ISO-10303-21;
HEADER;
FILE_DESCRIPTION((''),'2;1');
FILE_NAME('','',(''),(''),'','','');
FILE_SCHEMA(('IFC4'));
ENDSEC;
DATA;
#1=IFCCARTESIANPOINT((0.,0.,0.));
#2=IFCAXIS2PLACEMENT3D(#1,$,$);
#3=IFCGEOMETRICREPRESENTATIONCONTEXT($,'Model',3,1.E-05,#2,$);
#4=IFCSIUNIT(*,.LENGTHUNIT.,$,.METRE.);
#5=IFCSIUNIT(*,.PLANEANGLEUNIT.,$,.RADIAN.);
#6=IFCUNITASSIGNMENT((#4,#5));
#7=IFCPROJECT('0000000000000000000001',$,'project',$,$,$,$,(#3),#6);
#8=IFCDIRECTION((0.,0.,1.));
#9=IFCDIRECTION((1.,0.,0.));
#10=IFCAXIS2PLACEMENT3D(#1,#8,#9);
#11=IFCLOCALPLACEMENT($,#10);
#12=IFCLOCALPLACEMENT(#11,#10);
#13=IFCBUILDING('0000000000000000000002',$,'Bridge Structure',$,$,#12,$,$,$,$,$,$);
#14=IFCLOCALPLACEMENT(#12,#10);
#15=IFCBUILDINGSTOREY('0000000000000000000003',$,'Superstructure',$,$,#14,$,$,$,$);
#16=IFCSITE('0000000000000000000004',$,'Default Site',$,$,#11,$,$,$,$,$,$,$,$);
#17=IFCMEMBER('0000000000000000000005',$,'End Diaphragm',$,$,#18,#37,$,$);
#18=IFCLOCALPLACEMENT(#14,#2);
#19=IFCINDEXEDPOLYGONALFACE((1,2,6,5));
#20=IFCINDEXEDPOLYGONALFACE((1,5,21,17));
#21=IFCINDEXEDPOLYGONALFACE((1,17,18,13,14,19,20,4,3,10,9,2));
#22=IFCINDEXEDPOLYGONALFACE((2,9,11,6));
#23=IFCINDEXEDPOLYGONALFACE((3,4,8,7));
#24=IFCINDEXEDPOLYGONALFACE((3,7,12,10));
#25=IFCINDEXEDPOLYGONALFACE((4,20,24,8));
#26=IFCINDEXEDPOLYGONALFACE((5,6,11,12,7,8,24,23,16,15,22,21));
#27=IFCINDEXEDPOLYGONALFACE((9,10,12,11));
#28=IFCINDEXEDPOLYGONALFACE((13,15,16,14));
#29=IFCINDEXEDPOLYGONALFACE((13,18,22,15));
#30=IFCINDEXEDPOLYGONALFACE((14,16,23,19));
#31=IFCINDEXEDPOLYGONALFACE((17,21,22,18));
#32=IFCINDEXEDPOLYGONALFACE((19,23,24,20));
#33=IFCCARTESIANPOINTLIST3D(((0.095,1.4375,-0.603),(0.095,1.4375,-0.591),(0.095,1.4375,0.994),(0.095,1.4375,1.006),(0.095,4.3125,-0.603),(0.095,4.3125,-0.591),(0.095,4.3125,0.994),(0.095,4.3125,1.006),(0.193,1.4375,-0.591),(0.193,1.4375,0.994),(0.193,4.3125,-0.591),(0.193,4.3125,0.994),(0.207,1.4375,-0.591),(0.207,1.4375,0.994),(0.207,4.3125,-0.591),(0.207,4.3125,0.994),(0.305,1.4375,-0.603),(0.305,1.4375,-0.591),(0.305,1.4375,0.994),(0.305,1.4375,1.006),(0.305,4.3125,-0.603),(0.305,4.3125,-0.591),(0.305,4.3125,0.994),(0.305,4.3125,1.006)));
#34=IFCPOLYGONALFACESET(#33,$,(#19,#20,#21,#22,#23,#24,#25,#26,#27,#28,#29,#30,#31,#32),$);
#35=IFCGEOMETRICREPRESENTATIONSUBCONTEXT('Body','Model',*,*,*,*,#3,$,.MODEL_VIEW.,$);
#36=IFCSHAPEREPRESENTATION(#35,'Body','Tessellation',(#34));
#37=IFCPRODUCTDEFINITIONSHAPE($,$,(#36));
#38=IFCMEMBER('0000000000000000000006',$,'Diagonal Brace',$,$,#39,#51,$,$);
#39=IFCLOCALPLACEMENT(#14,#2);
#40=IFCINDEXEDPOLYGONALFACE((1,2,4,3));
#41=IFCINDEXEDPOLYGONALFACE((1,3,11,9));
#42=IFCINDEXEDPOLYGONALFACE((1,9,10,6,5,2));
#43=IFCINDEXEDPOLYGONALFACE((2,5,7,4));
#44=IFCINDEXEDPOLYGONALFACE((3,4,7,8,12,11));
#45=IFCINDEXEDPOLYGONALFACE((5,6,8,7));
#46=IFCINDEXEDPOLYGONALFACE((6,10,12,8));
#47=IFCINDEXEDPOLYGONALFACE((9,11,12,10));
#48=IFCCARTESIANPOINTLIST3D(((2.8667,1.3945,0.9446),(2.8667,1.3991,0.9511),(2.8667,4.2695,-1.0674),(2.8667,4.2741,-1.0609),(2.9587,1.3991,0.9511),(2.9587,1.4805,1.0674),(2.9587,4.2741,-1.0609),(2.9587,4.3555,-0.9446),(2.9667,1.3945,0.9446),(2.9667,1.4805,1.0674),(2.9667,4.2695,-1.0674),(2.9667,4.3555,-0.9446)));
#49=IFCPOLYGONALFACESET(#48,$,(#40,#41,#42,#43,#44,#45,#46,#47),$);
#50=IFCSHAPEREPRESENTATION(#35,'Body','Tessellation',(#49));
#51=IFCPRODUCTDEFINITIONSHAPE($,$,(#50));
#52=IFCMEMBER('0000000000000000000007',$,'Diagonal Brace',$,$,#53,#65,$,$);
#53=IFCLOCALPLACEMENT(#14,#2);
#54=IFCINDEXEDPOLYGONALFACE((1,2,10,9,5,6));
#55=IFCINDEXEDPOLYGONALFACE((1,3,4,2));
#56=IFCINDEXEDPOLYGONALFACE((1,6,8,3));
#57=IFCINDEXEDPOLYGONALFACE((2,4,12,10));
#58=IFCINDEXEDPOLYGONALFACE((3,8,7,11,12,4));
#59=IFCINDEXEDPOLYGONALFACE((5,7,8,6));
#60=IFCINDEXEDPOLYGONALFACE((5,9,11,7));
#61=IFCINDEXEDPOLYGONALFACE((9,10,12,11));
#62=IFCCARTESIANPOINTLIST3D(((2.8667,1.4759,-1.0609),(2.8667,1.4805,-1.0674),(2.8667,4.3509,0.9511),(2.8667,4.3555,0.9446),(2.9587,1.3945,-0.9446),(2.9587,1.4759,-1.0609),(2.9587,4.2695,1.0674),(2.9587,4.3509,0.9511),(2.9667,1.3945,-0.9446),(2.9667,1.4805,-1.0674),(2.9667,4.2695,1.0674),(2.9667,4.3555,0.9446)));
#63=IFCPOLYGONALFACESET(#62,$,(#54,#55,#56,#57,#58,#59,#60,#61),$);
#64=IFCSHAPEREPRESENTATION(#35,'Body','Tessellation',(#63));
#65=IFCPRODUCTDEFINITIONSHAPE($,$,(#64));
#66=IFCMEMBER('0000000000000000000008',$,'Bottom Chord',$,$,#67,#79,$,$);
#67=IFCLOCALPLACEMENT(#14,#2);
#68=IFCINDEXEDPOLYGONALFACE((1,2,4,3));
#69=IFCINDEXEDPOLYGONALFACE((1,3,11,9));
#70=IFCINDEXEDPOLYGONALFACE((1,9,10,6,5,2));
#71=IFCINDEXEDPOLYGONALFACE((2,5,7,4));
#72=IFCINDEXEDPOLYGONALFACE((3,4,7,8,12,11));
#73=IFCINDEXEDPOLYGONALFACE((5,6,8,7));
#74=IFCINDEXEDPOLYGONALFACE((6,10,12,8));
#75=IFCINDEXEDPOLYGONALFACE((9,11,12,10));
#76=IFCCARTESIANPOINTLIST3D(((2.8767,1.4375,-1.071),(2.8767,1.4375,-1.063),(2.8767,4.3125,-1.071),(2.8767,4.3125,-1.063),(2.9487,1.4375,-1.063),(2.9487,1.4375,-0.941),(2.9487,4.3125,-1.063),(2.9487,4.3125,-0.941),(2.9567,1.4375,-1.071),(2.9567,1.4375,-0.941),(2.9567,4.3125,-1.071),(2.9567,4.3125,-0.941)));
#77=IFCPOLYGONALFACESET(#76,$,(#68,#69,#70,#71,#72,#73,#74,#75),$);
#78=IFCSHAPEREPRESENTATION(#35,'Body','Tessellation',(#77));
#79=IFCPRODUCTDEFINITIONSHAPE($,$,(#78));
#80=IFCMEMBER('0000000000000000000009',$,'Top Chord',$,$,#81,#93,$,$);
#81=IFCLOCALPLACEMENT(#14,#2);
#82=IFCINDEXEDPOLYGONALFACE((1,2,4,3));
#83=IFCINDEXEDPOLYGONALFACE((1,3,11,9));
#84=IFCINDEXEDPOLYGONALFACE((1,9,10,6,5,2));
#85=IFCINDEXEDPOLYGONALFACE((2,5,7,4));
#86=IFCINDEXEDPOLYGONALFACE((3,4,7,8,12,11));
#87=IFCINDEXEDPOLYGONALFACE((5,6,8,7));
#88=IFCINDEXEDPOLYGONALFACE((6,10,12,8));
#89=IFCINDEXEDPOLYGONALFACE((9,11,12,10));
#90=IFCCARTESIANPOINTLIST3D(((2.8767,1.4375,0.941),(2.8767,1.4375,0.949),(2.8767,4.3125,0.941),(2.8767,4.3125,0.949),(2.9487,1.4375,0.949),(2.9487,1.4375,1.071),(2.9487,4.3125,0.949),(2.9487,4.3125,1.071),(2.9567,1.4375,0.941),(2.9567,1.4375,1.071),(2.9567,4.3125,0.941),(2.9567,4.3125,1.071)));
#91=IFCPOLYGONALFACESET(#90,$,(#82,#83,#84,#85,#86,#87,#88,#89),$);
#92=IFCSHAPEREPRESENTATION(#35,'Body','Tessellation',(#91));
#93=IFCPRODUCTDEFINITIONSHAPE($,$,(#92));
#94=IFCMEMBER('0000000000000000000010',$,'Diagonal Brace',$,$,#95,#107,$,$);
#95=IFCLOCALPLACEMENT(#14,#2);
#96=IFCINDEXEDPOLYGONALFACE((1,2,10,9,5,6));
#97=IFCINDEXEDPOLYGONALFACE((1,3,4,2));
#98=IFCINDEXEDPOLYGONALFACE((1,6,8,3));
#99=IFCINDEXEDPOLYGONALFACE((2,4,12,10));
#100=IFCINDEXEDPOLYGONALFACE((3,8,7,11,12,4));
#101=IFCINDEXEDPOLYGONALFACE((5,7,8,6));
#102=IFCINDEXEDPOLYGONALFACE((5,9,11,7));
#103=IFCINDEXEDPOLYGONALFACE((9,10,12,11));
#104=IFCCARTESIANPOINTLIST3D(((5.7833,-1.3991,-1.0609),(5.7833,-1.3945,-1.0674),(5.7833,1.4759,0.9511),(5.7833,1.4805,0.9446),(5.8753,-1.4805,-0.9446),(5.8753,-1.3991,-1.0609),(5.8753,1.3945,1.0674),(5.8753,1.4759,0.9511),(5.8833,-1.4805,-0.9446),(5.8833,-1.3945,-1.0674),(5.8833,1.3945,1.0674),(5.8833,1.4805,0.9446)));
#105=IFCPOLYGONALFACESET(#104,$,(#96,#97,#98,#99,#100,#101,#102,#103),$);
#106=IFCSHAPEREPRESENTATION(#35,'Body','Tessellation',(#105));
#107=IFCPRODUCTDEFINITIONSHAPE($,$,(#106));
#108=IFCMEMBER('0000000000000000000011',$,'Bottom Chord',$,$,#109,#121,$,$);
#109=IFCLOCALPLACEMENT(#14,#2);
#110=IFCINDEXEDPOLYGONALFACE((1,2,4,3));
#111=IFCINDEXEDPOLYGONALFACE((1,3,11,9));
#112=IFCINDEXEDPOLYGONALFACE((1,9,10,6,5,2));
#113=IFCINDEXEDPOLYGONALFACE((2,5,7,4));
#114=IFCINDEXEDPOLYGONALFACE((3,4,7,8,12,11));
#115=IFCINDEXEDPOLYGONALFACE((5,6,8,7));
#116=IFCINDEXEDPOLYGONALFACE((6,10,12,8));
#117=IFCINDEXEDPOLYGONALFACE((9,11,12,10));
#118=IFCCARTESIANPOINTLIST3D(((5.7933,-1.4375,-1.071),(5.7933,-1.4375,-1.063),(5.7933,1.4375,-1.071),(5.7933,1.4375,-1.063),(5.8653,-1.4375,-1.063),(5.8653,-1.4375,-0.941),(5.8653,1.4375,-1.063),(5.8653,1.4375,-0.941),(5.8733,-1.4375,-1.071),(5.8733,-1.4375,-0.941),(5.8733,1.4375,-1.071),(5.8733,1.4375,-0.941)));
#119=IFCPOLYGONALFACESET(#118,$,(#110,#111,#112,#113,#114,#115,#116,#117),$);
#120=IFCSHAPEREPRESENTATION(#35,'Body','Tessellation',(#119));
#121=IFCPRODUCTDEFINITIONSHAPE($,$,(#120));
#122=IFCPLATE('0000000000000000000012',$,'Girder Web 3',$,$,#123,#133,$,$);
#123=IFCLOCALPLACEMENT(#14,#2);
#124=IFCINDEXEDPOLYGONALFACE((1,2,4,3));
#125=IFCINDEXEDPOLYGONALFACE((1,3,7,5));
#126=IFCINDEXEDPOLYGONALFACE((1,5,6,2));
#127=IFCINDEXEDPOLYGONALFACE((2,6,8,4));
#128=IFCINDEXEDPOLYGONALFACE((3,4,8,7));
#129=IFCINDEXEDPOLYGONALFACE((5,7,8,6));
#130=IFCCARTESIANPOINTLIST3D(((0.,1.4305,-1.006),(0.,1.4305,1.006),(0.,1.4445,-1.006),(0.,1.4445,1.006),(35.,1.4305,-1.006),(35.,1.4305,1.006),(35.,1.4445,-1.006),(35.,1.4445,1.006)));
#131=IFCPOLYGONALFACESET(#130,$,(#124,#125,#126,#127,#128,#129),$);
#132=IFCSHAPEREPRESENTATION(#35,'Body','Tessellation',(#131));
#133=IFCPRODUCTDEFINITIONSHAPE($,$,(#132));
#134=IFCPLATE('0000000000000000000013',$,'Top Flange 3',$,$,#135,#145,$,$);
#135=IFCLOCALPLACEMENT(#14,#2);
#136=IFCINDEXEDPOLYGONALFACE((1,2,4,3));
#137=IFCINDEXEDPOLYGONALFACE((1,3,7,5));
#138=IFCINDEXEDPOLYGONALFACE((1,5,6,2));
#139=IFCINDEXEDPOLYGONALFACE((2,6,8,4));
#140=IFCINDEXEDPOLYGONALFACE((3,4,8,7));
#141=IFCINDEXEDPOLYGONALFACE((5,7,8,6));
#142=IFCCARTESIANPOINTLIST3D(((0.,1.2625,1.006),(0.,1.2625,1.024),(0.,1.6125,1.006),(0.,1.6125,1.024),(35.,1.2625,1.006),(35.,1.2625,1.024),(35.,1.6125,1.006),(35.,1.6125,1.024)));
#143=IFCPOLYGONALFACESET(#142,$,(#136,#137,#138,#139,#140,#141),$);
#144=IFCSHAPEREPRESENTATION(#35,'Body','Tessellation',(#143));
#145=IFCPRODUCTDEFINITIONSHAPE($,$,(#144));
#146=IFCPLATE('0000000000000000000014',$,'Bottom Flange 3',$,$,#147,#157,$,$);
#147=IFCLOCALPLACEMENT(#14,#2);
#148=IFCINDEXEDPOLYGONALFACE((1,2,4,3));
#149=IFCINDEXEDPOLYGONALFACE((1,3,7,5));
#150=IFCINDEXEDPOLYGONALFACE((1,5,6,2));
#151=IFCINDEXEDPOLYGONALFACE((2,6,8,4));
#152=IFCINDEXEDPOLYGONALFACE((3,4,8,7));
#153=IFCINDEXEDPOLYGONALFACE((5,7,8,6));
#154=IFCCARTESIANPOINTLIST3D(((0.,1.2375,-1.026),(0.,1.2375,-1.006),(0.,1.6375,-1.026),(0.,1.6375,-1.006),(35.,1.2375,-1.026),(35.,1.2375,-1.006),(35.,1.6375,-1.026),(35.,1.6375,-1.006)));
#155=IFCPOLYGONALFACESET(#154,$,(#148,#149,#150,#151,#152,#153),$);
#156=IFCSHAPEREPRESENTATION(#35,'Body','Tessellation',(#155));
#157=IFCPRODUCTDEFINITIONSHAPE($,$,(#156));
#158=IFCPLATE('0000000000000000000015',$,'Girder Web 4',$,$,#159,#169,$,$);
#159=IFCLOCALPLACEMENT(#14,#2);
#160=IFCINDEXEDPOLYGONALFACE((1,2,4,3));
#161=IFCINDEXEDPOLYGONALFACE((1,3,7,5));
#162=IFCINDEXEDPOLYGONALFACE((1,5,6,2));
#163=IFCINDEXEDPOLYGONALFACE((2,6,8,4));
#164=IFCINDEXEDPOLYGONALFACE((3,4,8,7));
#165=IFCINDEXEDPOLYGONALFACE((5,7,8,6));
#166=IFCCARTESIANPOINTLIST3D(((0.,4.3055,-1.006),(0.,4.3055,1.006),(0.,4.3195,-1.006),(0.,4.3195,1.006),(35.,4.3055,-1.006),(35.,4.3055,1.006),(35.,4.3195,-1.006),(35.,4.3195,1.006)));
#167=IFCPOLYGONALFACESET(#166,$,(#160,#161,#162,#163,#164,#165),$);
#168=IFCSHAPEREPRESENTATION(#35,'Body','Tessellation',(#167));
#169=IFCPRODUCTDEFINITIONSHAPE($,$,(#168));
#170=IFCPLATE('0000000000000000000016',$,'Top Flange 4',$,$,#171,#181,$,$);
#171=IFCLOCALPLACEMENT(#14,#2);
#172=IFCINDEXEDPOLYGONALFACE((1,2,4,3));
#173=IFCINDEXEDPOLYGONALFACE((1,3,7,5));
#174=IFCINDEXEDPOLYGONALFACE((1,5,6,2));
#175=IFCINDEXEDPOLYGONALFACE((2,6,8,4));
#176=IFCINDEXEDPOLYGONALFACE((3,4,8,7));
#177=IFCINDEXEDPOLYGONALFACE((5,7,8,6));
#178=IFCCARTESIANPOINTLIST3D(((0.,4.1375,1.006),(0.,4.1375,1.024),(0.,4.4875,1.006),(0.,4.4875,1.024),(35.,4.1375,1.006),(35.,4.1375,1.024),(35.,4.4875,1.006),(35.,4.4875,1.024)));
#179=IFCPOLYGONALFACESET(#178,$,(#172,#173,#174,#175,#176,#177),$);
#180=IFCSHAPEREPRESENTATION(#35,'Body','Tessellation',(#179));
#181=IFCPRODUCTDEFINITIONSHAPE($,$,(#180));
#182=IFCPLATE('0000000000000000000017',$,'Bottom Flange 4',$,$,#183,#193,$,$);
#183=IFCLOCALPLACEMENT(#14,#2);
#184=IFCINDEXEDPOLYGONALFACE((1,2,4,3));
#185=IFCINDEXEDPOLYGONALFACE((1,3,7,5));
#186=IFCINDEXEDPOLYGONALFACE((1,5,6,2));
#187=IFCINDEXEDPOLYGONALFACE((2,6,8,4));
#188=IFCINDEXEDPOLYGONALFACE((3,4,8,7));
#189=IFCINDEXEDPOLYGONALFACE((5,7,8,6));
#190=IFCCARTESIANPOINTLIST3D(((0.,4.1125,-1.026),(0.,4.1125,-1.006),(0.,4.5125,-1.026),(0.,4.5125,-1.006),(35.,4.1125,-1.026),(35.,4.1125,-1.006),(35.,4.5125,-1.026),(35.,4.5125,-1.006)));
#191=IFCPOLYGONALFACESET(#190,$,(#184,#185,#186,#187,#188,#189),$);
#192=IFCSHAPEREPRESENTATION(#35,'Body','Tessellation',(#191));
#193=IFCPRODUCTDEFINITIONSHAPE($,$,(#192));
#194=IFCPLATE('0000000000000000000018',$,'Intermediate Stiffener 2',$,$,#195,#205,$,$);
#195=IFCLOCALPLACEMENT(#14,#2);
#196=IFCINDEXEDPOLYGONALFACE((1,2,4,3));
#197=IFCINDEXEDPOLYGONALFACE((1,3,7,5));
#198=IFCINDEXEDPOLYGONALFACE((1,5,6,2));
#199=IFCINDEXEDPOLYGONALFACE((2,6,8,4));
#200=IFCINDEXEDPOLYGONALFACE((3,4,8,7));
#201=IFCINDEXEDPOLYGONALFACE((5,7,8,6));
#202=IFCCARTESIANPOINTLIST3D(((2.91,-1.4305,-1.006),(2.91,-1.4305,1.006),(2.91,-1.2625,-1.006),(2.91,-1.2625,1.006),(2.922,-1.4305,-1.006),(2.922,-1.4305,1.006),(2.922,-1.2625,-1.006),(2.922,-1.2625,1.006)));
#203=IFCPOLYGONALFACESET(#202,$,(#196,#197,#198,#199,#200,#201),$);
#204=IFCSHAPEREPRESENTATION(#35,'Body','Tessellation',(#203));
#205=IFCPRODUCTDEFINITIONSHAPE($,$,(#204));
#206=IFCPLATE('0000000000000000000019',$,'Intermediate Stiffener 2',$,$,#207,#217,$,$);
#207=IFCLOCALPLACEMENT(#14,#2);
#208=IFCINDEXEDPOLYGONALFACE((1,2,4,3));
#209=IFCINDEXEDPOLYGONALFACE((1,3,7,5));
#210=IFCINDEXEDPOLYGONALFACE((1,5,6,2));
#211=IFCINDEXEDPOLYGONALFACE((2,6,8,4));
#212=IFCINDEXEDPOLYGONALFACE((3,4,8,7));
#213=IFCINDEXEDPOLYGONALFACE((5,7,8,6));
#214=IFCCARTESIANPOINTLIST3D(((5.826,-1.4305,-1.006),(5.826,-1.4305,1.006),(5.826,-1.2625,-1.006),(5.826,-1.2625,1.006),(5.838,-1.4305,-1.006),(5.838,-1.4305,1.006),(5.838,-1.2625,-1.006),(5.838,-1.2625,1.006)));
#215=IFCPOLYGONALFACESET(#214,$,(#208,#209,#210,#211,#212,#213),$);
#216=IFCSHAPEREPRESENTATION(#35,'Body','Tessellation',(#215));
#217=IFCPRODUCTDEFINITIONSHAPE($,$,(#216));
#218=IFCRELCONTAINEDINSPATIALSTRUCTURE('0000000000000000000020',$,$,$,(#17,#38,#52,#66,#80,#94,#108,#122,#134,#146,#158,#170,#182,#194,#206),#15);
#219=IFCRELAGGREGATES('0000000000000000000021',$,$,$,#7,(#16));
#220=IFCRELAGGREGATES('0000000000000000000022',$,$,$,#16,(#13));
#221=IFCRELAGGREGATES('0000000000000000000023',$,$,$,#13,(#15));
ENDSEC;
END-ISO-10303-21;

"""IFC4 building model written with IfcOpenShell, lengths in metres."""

from ifc_helpers import new_model, si_unit, frame, origin, origin_with_axes, origin_2d_with_axis, place, context, subcontext, project, spatial, rectangle, i_section, l_section, extrude, element, save


model = new_model("IFC4")

# Units and contexts
model_context = context("Model", 3, precision=1e-05, world=origin())
body_context = subcontext(model_context, "Body", "Model", "MODEL_VIEW")
ifc_project = project(units=[si_unit("LENGTHUNIT", "METRE"), si_unit("PLANEANGLEUNIT", "RADIAN")], contexts=[model_context])

# Site, building, storey
site_placement = place(None, origin_with_axes())
site = spatial("IfcSite", under=ifc_project, at=site_placement, Name="Default Site")
building_placement = place(site_placement, origin_with_axes())
building = spatial("IfcBuilding", under=site, at=building_placement, Name="Bridge Structure")
storey_placement = place(building_placement, origin_with_axes())
storey = spatial("IfcBuildingStorey", under=building, at=storey_placement, Name="Superstructure")

# Members
member_1_placement = place(storey_placement, frame((0.2, 1.4375, 0.2015), z_axis=(0.0, 1.0, 0.0), x_axis=(-1.0, 0.0, 0.0)))
element("IfcMember", 1, at=member_1_placement, inside=storey, Name="End Diaphragm", context=body_context, shape_type="SweptSolid", body=[
    extrude(i_section(OverallWidth=0.21, OverallDepth=1.609, WebThickness=0.014, FlangeThickness=0.012, at=origin_2d_with_axis()), origin_with_axes(), (0.0, 0.0, 1.0), 2.875),
])
for number, where, z_axis, x_axis, name in (
    (2, (2.9167, 1.4375, 1.006), (0.0, 0.819299, -0.573367), (-1.0, 0.0, 0.0), "Diagonal Brace"),
    (3, (2.9167, 1.4375, -1.006), (0.0, 0.819299, 0.573367), (-1.0, 0.0, 0.0), "Diagonal Brace"),
):
    element("IfcMember", number, at=place(storey_placement, frame(where, z_axis=z_axis, x_axis=x_axis)), inside=storey, Name=name, context=body_context, shape_type="SweptSolid", body=[
        extrude(l_section(Depth=0.15, Width=0.1, Thickness=0.008, at=origin_2d_with_axis()), origin_with_axes(), (0.0, 0.0, 1.0), 3.5091),
    ])
for number, where, z_axis, x_axis, name in (
    (4, (2.9167, 1.4375, -1.006), (0.0, 1.0, 0.0), (-1.0, 0.0, 0.0), "Bottom Chord"),
    (5, (2.9167, 1.4375, 1.006), (0.0, 1.0, 0.0), (-1.0, 0.0, 0.0), "Top Chord"),
):
    element("IfcMember", number, at=place(storey_placement, frame(where, z_axis=z_axis, x_axis=x_axis)), inside=storey, Name=name, context=body_context, shape_type="SweptSolid", body=[
        extrude(l_section(Depth=0.13, Width=0.08, Thickness=0.008, at=origin_2d_with_axis()), origin_with_axes(), (0.0, 0.0, 1.0), 2.875),
    ])
member_2_placement = place(storey_placement, frame((5.8333, -1.4375, -1.006), z_axis=(0.0, 0.819299, 0.573367), x_axis=(-1.0, 0.0, 0.0)))
element("IfcMember", 6, at=member_2_placement, inside=storey, Name="Diagonal Brace", context=body_context, shape_type="SweptSolid", body=[
    extrude(l_section(Depth=0.15, Width=0.1, Thickness=0.008, at=origin_2d_with_axis()), origin_with_axes(), (0.0, 0.0, 1.0), 3.5091),
])
member_3_placement = place(storey_placement, frame((5.8333, -1.4375, -1.006), z_axis=(0.0, 1.0, 0.0), x_axis=(-1.0, 0.0, 0.0)))
element("IfcMember", 7, at=member_3_placement, inside=storey, Name="Bottom Chord", context=body_context, shape_type="SweptSolid", body=[
    extrude(l_section(Depth=0.13, Width=0.08, Thickness=0.008, at=origin_2d_with_axis()), origin_with_axes(), (0.0, 0.0, 1.0), 2.875),
])

# Plates
plate_1_placement = place(storey_placement, frame((0.0, 1.4375, 0.0), z_axis=(1.0, 0.0, 0.0), x_axis=(0.0, 1.0, 0.0)))
element("IfcPlate", 8, at=plate_1_placement, inside=storey, Name="Girder Web 3", context=body_context, shape_type="SweptSolid", body=[
    extrude(rectangle(XDim=0.014, YDim=2.012, at=origin_2d_with_axis()), origin_with_axes(), (0.0, 0.0, 1.0), 35.0),
])
plate_2_placement = place(storey_placement, frame((0.0, 1.4375, 1.015), z_axis=(1.0, 0.0, 0.0), x_axis=(0.0, 1.0, 0.0)))
element("IfcPlate", 9, at=plate_2_placement, inside=storey, Name="Top Flange 3", context=body_context, shape_type="SweptSolid", body=[
    extrude(rectangle(XDim=0.35, YDim=0.018, at=origin_2d_with_axis()), origin_with_axes(), (0.0, 0.0, 1.0), 35.0),
])
plate_3_placement = place(storey_placement, frame((0.0, 1.4375, -1.016), z_axis=(1.0, 0.0, 0.0), x_axis=(0.0, 1.0, 0.0)))
element("IfcPlate", 10, at=plate_3_placement, inside=storey, Name="Bottom Flange 3", context=body_context, shape_type="SweptSolid", body=[
    extrude(rectangle(XDim=0.4, YDim=0.02, at=origin_2d_with_axis()), origin_with_axes(), (0.0, 0.0, 1.0), 35.0),
])
plate_4_placement = place(storey_placement, frame((0.0, 4.3125, 0.0), z_axis=(1.0, 0.0, 0.0), x_axis=(0.0, 1.0, 0.0)))
element("IfcPlate", 11, at=plate_4_placement, inside=storey, Name="Girder Web 4", context=body_context, shape_type="SweptSolid", body=[
    extrude(rectangle(XDim=0.014, YDim=2.012, at=origin_2d_with_axis()), origin_with_axes(), (0.0, 0.0, 1.0), 35.0),
])
plate_5_placement = place(storey_placement, frame((0.0, 4.3125, 1.015), z_axis=(1.0, 0.0, 0.0), x_axis=(0.0, 1.0, 0.0)))
element("IfcPlate", 12, at=plate_5_placement, inside=storey, Name="Top Flange 4", context=body_context, shape_type="SweptSolid", body=[
    extrude(rectangle(XDim=0.35, YDim=0.018, at=origin_2d_with_axis()), origin_with_axes(), (0.0, 0.0, 1.0), 35.0),
])
plate_6_placement = place(storey_placement, frame((0.0, 4.3125, -1.016), z_axis=(1.0, 0.0, 0.0), x_axis=(0.0, 1.0, 0.0)))
element("IfcPlate", 13, at=plate_6_placement, inside=storey, Name="Bottom Flange 4", context=body_context, shape_type="SweptSolid", body=[
    extrude(rectangle(XDim=0.4, YDim=0.02, at=origin_2d_with_axis()), origin_with_axes(), (0.0, 0.0, 1.0), 35.0),
])
for number, where, z_axis, x_axis, name in (
    (14, (2.916, -1.3465, -1.006), (0.0, 0.0, 1.0), (1.0, 0.0, 0.0), "Intermediate Stiffener 2"),
    (15, (5.832, -1.3465, -1.006), (0.0, 0.0, 1.0), (1.0, 0.0, 0.0), "Intermediate Stiffener 2"),
):
    element("IfcPlate", number, at=place(storey_placement, frame(where, z_axis=z_axis, x_axis=x_axis)), inside=storey, Name=name, context=body_context, shape_type="SweptSolid", body=[
        extrude(rectangle(XDim=0.012, YDim=0.168, at=origin_2d_with_axis()), origin_with_axes(), (0.0, 0.0, 1.0), 2.012),
    ])

save(model, "model.ifc")
